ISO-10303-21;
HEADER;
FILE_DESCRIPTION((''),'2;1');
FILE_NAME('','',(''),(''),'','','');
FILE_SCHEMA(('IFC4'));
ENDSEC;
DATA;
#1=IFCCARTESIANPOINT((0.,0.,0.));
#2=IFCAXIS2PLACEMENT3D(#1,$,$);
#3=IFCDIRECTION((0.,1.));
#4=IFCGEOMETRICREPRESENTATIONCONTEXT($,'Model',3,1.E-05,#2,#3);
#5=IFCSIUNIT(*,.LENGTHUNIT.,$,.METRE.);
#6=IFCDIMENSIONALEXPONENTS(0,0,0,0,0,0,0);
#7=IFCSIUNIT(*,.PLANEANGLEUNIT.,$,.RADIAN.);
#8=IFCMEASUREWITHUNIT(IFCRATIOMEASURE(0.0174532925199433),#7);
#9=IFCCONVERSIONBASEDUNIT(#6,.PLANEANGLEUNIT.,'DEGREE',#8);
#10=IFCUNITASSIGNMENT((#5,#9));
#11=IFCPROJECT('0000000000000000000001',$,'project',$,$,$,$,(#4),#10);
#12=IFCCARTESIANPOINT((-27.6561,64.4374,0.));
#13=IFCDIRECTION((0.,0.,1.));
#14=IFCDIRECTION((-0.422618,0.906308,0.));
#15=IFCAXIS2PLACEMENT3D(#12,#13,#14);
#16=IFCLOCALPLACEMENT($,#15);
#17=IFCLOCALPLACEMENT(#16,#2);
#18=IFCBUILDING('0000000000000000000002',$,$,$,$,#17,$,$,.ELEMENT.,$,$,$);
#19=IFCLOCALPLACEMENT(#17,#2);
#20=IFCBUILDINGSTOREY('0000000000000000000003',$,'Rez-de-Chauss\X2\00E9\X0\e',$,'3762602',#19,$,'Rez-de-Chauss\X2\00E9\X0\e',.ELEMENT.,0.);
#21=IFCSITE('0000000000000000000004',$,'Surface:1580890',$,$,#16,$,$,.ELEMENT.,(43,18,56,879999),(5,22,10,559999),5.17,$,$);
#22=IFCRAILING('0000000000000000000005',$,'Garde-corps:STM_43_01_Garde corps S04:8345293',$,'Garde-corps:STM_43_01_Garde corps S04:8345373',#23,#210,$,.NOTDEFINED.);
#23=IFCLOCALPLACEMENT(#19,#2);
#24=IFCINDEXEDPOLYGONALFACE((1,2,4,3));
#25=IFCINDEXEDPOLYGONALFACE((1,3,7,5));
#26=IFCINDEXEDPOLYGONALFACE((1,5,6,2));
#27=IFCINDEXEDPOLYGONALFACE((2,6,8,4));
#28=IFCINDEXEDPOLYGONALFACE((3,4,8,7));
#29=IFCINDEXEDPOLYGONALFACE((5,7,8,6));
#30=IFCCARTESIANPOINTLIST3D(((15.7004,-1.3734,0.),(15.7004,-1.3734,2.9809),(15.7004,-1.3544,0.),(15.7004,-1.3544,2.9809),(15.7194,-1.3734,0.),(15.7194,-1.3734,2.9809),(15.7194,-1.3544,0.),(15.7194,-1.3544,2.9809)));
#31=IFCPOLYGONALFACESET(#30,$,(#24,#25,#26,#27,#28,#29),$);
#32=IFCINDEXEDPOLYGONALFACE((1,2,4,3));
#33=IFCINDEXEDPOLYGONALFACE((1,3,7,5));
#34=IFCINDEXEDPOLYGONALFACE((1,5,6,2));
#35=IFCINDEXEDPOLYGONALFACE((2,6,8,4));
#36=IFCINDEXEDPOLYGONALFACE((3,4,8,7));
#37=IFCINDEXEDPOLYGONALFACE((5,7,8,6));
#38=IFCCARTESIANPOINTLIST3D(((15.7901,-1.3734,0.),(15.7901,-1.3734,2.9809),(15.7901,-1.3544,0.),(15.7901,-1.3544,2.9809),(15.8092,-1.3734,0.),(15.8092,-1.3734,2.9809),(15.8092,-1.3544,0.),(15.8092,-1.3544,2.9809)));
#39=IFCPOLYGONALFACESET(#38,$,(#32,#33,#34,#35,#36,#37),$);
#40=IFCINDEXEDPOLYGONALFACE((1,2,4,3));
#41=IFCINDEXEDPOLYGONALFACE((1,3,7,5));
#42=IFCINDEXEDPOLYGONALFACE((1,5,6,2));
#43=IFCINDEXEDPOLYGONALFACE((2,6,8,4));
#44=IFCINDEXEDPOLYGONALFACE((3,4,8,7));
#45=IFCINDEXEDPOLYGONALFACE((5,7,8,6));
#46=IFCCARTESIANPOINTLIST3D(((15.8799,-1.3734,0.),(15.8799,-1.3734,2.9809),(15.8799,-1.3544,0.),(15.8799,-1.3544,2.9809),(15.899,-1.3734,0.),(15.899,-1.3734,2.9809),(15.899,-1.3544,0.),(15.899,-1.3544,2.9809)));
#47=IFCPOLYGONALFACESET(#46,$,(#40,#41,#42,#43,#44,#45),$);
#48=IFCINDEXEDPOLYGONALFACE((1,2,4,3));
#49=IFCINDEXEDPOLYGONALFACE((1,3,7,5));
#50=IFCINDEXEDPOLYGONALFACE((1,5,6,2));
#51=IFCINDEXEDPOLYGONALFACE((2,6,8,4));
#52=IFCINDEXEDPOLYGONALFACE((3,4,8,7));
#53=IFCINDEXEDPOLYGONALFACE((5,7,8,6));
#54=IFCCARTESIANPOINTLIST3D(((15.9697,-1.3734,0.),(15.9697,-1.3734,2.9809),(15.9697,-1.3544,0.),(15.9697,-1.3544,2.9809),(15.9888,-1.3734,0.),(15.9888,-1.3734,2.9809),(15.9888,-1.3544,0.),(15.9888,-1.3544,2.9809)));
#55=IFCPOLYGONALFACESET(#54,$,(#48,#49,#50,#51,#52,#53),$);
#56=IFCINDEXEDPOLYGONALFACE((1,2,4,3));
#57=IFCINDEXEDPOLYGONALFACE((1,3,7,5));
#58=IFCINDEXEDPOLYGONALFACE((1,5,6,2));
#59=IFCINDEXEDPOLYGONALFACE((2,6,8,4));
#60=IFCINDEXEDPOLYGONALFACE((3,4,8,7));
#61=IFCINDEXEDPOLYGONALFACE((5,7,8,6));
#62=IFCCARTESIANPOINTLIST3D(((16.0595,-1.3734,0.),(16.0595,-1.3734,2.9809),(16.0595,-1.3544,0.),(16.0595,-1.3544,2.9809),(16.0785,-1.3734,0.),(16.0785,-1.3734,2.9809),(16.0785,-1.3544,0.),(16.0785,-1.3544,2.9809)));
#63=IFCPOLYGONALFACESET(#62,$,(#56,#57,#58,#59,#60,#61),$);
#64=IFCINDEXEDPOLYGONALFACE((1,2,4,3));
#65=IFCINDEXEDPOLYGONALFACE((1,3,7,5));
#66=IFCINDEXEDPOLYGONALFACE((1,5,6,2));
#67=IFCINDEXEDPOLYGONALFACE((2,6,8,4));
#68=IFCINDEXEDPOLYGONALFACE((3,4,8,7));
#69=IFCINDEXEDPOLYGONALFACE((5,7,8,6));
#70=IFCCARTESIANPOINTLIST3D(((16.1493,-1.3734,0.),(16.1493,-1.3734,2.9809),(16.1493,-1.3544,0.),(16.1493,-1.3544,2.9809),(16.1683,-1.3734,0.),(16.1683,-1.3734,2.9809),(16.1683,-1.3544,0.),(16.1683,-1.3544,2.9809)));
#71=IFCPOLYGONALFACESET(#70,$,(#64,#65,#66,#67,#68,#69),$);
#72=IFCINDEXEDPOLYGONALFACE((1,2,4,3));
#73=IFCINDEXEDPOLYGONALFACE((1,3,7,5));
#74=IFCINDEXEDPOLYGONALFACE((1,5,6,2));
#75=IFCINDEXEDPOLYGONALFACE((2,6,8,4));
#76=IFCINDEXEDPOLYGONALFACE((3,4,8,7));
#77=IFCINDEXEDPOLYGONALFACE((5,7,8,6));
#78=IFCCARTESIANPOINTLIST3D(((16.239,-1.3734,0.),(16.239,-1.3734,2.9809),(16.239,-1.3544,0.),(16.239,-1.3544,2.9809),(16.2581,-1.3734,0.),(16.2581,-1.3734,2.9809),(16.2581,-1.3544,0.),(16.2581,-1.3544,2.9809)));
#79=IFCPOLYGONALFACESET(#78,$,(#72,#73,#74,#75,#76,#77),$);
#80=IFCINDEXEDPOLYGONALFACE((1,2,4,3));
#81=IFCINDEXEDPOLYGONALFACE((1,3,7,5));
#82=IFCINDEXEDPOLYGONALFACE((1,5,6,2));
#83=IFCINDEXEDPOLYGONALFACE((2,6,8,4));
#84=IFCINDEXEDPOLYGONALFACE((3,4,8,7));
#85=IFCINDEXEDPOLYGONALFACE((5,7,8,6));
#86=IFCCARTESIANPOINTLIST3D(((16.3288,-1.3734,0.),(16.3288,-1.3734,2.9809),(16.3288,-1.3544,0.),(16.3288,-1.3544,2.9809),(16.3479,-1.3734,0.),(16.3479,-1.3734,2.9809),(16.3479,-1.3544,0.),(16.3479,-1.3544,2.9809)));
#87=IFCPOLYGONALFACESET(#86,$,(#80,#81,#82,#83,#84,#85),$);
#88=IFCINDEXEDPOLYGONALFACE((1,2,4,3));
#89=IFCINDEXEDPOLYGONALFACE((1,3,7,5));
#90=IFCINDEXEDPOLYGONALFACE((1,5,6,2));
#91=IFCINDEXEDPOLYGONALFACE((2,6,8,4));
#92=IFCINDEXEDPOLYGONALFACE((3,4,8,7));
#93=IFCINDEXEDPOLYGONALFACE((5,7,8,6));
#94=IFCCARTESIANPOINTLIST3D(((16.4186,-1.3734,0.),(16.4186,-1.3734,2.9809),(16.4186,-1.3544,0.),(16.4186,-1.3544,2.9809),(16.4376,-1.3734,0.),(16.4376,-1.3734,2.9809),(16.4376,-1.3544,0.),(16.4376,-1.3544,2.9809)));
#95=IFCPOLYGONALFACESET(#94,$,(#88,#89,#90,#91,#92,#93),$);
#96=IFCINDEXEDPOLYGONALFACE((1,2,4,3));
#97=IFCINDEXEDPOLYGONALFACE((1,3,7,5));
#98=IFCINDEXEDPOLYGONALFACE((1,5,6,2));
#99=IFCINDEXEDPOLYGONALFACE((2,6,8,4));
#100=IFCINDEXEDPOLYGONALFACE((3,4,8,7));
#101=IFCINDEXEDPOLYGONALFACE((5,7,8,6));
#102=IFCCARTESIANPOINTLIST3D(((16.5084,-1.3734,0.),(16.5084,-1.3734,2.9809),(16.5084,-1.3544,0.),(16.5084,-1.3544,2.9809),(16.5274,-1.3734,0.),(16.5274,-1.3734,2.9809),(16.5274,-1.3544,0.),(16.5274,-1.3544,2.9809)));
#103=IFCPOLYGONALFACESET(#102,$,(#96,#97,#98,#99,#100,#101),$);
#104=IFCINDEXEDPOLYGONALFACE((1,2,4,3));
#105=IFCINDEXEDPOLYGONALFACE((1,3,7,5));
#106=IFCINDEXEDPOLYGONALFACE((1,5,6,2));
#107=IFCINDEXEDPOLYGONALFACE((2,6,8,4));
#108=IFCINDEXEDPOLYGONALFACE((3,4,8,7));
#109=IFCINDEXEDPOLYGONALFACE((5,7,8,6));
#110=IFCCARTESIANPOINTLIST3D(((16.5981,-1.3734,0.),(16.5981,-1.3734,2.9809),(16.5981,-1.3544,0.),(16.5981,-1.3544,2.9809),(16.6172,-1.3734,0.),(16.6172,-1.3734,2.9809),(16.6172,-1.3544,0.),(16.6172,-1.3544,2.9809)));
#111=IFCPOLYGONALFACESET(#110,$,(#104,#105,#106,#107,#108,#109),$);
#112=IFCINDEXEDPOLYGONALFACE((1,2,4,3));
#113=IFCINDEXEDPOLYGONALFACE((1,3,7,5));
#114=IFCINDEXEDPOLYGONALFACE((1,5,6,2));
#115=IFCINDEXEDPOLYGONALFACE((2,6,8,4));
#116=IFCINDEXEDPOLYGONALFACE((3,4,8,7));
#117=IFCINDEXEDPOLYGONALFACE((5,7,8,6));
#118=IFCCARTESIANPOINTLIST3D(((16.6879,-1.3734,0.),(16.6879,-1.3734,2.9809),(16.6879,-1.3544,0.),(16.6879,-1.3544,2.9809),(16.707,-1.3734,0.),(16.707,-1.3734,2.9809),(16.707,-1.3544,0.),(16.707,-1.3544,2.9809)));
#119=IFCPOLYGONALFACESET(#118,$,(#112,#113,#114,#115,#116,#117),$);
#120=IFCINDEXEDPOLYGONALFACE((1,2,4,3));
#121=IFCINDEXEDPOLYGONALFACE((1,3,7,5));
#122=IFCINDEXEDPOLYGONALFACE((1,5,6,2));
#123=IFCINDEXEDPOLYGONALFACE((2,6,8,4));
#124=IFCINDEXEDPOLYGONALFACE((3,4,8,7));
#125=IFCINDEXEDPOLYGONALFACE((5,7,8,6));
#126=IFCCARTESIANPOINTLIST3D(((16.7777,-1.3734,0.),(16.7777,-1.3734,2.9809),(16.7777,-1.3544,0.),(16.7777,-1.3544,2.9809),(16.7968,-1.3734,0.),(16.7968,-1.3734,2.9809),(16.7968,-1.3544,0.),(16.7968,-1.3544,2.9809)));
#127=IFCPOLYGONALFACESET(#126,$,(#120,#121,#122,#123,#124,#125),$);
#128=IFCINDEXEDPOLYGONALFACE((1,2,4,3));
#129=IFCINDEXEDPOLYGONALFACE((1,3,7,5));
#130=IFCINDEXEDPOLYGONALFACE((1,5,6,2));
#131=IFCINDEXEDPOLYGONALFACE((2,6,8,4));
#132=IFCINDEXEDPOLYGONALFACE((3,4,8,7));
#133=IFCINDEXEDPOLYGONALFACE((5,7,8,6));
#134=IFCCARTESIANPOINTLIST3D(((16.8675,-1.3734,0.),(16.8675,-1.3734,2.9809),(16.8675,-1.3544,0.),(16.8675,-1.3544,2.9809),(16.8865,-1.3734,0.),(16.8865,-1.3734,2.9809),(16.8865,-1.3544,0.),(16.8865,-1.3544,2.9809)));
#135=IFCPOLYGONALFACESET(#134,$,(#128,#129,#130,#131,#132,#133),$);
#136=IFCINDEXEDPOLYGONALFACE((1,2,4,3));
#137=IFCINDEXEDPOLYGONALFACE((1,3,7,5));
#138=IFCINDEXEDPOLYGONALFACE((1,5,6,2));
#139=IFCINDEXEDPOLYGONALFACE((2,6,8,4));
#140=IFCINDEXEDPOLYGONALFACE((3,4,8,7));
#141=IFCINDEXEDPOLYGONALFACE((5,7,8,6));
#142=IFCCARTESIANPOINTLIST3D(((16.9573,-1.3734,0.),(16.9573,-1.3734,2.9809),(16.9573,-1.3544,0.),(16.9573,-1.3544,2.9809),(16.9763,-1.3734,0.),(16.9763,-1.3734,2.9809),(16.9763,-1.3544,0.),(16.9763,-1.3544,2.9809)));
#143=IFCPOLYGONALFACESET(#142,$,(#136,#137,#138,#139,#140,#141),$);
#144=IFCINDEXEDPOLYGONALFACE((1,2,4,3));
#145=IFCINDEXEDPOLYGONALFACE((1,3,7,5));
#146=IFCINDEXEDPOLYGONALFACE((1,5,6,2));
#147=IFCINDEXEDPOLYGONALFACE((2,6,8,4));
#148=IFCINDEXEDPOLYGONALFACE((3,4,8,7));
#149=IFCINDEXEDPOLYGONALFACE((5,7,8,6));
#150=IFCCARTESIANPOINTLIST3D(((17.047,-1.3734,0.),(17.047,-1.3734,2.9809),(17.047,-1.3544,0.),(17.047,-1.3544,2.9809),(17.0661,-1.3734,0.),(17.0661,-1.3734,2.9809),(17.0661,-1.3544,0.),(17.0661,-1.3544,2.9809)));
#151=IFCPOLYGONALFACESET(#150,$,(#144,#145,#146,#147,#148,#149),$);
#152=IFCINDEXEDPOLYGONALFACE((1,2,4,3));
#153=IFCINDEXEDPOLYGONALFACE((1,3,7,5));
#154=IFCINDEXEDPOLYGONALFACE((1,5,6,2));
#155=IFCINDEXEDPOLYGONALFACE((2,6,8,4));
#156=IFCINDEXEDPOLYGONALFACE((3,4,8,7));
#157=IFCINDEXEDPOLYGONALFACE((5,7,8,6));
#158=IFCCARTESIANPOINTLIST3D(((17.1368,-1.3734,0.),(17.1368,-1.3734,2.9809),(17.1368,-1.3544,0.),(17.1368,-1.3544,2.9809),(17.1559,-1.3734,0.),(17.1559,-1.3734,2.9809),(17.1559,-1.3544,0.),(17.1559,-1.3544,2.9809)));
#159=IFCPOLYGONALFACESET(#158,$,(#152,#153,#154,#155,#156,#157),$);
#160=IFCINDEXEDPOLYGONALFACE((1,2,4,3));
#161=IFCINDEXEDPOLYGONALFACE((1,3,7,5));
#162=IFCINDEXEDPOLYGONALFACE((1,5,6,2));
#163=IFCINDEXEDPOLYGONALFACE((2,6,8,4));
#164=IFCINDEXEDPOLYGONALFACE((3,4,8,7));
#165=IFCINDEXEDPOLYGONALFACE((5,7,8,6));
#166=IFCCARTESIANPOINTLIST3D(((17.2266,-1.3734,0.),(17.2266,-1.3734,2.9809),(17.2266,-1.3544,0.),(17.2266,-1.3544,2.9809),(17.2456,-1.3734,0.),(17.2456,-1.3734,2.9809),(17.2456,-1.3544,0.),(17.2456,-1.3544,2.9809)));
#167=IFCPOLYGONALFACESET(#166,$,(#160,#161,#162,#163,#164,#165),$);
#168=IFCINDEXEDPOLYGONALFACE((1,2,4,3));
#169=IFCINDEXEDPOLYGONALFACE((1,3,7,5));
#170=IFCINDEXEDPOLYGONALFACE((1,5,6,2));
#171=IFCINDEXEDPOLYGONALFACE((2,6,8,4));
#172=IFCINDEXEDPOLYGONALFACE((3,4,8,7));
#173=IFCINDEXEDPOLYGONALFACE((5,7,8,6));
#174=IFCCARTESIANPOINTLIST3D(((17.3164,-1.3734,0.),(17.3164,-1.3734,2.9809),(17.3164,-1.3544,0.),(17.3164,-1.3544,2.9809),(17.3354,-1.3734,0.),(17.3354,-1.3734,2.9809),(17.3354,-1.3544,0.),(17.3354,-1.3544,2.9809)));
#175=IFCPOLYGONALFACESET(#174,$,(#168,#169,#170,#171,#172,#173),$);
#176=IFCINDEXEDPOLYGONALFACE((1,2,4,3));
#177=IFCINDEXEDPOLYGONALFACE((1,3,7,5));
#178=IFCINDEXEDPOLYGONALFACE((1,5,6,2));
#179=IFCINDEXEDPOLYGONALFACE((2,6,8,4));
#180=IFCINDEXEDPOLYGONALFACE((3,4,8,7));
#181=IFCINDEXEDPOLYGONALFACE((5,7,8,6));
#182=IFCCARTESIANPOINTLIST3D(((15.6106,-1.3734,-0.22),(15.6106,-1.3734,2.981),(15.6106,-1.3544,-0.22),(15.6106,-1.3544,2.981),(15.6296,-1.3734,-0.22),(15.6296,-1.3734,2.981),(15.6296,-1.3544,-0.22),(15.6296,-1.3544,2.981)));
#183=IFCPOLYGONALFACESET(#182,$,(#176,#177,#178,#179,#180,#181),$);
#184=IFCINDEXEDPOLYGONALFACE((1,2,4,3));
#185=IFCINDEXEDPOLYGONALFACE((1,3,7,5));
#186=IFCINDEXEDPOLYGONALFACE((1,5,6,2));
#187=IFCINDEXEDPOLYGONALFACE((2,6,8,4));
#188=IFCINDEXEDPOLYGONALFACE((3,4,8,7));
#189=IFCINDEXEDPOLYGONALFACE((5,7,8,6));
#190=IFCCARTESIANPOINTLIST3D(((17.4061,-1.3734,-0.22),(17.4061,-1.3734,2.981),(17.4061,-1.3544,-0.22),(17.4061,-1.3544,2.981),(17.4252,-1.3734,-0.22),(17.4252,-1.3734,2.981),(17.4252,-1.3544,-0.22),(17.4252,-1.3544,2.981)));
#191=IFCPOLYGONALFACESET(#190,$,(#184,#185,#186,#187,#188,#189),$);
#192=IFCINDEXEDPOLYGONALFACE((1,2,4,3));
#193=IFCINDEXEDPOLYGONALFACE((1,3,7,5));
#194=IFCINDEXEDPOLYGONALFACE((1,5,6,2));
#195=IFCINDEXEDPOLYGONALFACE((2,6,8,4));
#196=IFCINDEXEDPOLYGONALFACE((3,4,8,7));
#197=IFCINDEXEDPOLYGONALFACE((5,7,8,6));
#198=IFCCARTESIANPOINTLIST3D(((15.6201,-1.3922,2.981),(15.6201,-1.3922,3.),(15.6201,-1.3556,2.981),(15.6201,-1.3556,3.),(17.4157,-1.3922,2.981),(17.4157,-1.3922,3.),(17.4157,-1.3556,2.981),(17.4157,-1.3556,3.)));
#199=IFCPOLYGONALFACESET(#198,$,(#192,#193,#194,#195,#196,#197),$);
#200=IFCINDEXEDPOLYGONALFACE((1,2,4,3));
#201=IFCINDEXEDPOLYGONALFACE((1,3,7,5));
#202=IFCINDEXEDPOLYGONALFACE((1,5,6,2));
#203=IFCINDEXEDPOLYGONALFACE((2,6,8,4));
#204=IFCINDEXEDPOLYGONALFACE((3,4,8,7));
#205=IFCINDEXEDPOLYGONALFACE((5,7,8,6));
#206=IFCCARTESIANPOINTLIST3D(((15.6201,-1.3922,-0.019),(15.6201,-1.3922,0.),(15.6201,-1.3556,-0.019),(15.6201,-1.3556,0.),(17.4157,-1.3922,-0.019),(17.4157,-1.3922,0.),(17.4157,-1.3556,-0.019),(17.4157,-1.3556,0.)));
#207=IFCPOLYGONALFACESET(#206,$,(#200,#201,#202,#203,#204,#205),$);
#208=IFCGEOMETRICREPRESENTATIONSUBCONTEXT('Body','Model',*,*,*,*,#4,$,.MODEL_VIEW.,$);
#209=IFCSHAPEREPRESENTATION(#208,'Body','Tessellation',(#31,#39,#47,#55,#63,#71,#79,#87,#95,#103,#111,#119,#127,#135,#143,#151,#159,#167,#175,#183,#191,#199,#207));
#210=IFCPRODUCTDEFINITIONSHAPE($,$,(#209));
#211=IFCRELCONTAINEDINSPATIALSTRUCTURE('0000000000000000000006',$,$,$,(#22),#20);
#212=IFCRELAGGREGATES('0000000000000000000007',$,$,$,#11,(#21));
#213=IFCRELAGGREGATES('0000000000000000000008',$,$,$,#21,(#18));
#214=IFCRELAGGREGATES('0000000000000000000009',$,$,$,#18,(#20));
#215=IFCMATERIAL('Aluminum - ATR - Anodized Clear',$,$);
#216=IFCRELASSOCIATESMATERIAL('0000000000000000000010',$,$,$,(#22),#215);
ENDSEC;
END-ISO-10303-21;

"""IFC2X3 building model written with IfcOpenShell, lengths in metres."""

from ifc_helpers import new_model, entity, si_unit, converted_unit, direction, frame, frame_2d, origin, origin_2d_with_axis, place, context, subcontext, project, spatial, rectangle, extrude, material, element, save


model = new_model("IFC2X3")

# Units and contexts
model_context = context("Model", 3, precision=1e-05, world=origin(), true_north=direction((0.0, 1.0)))
body_context = subcontext(model_context, "Body", "Model", "MODEL_VIEW")
ifc_project = project(units=[si_unit("LENGTHUNIT", "METRE"), converted_unit("PLANEANGLEUNIT", "DEGREE", entity("IfcRatioMeasure", 0.0174532925199433), si_unit("PLANEANGLEUNIT", "RADIAN"), dimensions=[0, 0, 0, 0, 0, 0, 0])], contexts=[model_context])

# Site, building, storey
site_placement = place(None, frame((-27.6561, 64.4374, 0.0), z_axis=(0.0, 0.0, 1.0), x_axis=(-0.422618, 0.906308, 0.0)))
site = spatial("IfcSite", under=ifc_project, at=site_placement, Name="Surface:1580890", CompositionType="ELEMENT", RefLatitude=(43, 18, 56, 879999), RefLongitude=(5, 22, 10, 559999), RefElevation=5.17)
building_placement = place(site_placement, origin())
building = spatial("IfcBuilding", under=site, at=building_placement, CompositionType="ELEMENT")
storey_placement = place(building_placement, origin())
storey = spatial("IfcBuildingStorey", under=building, at=storey_placement, Name="Rez-de-Chaussée", ObjectType="3762602", LongName="Rez-de-Chaussée", CompositionType="ELEMENT", Elevation=0.0)

# Railing
ifc_material_1 = material(Name="Aluminum - ATR - Anodized Clear")
railing_1_placement = place(storey_placement, origin())
element("IfcRailing", 1, at=railing_1_placement, inside=storey, material=ifc_material_1, Name="Garde-corps:STM_43_01_Garde corps S04:8345293", ObjectType="Garde-corps:STM_43_01_Garde corps S04:8345373", PredefinedType="NOTDEFINED", context=body_context, shape_type="SweptSolid", body=[
    extrude(rectangle(XDim=0.0191, YDim=0.019, at=origin_2d_with_axis()), frame((15.7099, -1.3639, 0.0), z_axis=(0.0, 0.0, 1.0), x_axis=(-1.0, 0.0, 0.0)), (0.0, 0.0, 1.0), 2.9809),
    extrude(rectangle(XDim=0.0191, YDim=0.019, at=origin_2d_with_axis()), frame((15.7997, -1.3639, 0.0), z_axis=(0.0, 0.0, 1.0), x_axis=(-1.0, 0.0, 0.0)), (0.0, 0.0, 1.0), 2.9809),
    extrude(rectangle(XDim=0.0191, YDim=0.019, at=origin_2d_with_axis()), frame((15.8894, -1.3639, 0.0), z_axis=(0.0, 0.0, 1.0), x_axis=(-1.0, 0.0, 0.0)), (0.0, 0.0, 1.0), 2.9809),
    extrude(rectangle(XDim=0.0191, YDim=0.019, at=origin_2d_with_axis()), frame((15.9792, -1.3639, 0.0), z_axis=(0.0, 0.0, 1.0), x_axis=(-1.0, 0.0, 0.0)), (0.0, 0.0, 1.0), 2.9809),
    extrude(rectangle(XDim=0.0191, YDim=0.019, at=origin_2d_with_axis()), frame((16.069, -1.3639, 0.0), z_axis=(0.0, 0.0, 1.0), x_axis=(-1.0, 0.0, 0.0)), (0.0, 0.0, 1.0), 2.9809),
    extrude(rectangle(XDim=0.0191, YDim=0.019, at=origin_2d_with_axis()), frame((16.1588, -1.3639, 0.0), z_axis=(0.0, 0.0, 1.0), x_axis=(-1.0, 0.0, 0.0)), (0.0, 0.0, 1.0), 2.9809),
    extrude(rectangle(XDim=0.0191, YDim=0.019, at=origin_2d_with_axis()), frame((16.2486, -1.3639, 0.0), z_axis=(0.0, 0.0, 1.0), x_axis=(-1.0, 0.0, 0.0)), (0.0, 0.0, 1.0), 2.9809),
    extrude(rectangle(XDim=0.0191, YDim=0.019, at=origin_2d_with_axis()), frame((16.3383, -1.3639, 0.0), z_axis=(0.0, 0.0, 1.0), x_axis=(-1.0, 0.0, 0.0)), (0.0, 0.0, 1.0), 2.9809),
    extrude(rectangle(XDim=0.0191, YDim=0.019, at=origin_2d_with_axis()), frame((16.4281, -1.3639, 0.0), z_axis=(0.0, 0.0, 1.0), x_axis=(-1.0, 0.0, 0.0)), (0.0, 0.0, 1.0), 2.9809),
    extrude(rectangle(XDim=0.0191, YDim=0.019, at=origin_2d_with_axis()), frame((16.5179, -1.3639, 0.0), z_axis=(0.0, 0.0, 1.0), x_axis=(-1.0, 0.0, 0.0)), (0.0, 0.0, 1.0), 2.9809),
    extrude(rectangle(XDim=0.0191, YDim=0.019, at=origin_2d_with_axis()), frame((16.6077, -1.3639, 0.0), z_axis=(0.0, 0.0, 1.0), x_axis=(-1.0, 0.0, 0.0)), (0.0, 0.0, 1.0), 2.9809),
    extrude(rectangle(XDim=0.0191, YDim=0.019, at=origin_2d_with_axis()), frame((16.6975, -1.3639, 0.0), z_axis=(0.0, 0.0, 1.0), x_axis=(-1.0, 0.0, 0.0)), (0.0, 0.0, 1.0), 2.9809),
    extrude(rectangle(XDim=0.0191, YDim=0.019, at=origin_2d_with_axis()), frame((16.7872, -1.3639, 0.0), z_axis=(0.0, 0.0, 1.0), x_axis=(-1.0, 0.0, 0.0)), (0.0, 0.0, 1.0), 2.9809),
    extrude(rectangle(XDim=0.0191, YDim=0.019, at=origin_2d_with_axis()), frame((16.877, -1.3639, 0.0), z_axis=(0.0, 0.0, 1.0), x_axis=(-1.0, 0.0, 0.0)), (0.0, 0.0, 1.0), 2.9809),
    extrude(rectangle(XDim=0.0191, YDim=0.019, at=origin_2d_with_axis()), frame((16.9668, -1.3639, 0.0), z_axis=(0.0, 0.0, 1.0), x_axis=(-1.0, 0.0, 0.0)), (0.0, 0.0, 1.0), 2.9809),
    extrude(rectangle(XDim=0.0191, YDim=0.019, at=origin_2d_with_axis()), frame((17.0566, -1.3639, 0.0), z_axis=(0.0, 0.0, 1.0), x_axis=(-1.0, 0.0, 0.0)), (0.0, 0.0, 1.0), 2.9809),
    extrude(rectangle(XDim=0.0191, YDim=0.019, at=origin_2d_with_axis()), frame((17.1463, -1.3639, 0.0), z_axis=(0.0, 0.0, 1.0), x_axis=(-1.0, 0.0, 0.0)), (0.0, 0.0, 1.0), 2.9809),
    extrude(rectangle(XDim=0.0191, YDim=0.019, at=origin_2d_with_axis()), frame((17.2361, -1.3639, 0.0), z_axis=(0.0, 0.0, 1.0), x_axis=(-1.0, 0.0, 0.0)), (0.0, 0.0, 1.0), 2.9809),
    extrude(rectangle(XDim=0.0191, YDim=0.019, at=origin_2d_with_axis()), frame((17.3259, -1.3639, 0.0), z_axis=(0.0, 0.0, 1.0), x_axis=(-1.0, 0.0, 0.0)), (0.0, 0.0, 1.0), 2.9809),
    extrude(rectangle(XDim=0.0191, YDim=0.019, at=origin_2d_with_axis()), frame((15.6201, -1.3639, -0.22), z_axis=(0.0, 0.0, 1.0), x_axis=(-1.0, 0.0, 0.0)), (0.0, 0.0, 1.0), 3.201),
    extrude(rectangle(XDim=0.0191, YDim=0.019, at=origin_2d_with_axis()), frame((17.4157, -1.3639, -0.22), z_axis=(0.0, 0.0, 1.0), x_axis=(-1.0, 0.0, 0.0)), (0.0, 0.0, 1.0), 3.201),
    extrude(rectangle(XDim=1.7956, YDim=0.0366, at=frame_2d((0.0, 0.0), x_axis=(1.0, 0.0))), frame((16.5179, -1.3739, 2.9809), z_axis=(0.0, 0.0, 1.0), x_axis=(-1.0, 0.0, 0.0)), (0.0, 0.0, 1.0), 0.0191),
    extrude(rectangle(XDim=1.7956, YDim=0.0366, at=frame_2d((0.0, 0.0), x_axis=(1.0, 0.0))), frame((16.5179, -1.3739, -0.019), z_axis=(0.0, 0.0, 1.0), x_axis=(-1.0, 0.0, 0.0)), (0.0, 0.0, 1.0), 0.0191),
])

save(model, "model.ifc")
